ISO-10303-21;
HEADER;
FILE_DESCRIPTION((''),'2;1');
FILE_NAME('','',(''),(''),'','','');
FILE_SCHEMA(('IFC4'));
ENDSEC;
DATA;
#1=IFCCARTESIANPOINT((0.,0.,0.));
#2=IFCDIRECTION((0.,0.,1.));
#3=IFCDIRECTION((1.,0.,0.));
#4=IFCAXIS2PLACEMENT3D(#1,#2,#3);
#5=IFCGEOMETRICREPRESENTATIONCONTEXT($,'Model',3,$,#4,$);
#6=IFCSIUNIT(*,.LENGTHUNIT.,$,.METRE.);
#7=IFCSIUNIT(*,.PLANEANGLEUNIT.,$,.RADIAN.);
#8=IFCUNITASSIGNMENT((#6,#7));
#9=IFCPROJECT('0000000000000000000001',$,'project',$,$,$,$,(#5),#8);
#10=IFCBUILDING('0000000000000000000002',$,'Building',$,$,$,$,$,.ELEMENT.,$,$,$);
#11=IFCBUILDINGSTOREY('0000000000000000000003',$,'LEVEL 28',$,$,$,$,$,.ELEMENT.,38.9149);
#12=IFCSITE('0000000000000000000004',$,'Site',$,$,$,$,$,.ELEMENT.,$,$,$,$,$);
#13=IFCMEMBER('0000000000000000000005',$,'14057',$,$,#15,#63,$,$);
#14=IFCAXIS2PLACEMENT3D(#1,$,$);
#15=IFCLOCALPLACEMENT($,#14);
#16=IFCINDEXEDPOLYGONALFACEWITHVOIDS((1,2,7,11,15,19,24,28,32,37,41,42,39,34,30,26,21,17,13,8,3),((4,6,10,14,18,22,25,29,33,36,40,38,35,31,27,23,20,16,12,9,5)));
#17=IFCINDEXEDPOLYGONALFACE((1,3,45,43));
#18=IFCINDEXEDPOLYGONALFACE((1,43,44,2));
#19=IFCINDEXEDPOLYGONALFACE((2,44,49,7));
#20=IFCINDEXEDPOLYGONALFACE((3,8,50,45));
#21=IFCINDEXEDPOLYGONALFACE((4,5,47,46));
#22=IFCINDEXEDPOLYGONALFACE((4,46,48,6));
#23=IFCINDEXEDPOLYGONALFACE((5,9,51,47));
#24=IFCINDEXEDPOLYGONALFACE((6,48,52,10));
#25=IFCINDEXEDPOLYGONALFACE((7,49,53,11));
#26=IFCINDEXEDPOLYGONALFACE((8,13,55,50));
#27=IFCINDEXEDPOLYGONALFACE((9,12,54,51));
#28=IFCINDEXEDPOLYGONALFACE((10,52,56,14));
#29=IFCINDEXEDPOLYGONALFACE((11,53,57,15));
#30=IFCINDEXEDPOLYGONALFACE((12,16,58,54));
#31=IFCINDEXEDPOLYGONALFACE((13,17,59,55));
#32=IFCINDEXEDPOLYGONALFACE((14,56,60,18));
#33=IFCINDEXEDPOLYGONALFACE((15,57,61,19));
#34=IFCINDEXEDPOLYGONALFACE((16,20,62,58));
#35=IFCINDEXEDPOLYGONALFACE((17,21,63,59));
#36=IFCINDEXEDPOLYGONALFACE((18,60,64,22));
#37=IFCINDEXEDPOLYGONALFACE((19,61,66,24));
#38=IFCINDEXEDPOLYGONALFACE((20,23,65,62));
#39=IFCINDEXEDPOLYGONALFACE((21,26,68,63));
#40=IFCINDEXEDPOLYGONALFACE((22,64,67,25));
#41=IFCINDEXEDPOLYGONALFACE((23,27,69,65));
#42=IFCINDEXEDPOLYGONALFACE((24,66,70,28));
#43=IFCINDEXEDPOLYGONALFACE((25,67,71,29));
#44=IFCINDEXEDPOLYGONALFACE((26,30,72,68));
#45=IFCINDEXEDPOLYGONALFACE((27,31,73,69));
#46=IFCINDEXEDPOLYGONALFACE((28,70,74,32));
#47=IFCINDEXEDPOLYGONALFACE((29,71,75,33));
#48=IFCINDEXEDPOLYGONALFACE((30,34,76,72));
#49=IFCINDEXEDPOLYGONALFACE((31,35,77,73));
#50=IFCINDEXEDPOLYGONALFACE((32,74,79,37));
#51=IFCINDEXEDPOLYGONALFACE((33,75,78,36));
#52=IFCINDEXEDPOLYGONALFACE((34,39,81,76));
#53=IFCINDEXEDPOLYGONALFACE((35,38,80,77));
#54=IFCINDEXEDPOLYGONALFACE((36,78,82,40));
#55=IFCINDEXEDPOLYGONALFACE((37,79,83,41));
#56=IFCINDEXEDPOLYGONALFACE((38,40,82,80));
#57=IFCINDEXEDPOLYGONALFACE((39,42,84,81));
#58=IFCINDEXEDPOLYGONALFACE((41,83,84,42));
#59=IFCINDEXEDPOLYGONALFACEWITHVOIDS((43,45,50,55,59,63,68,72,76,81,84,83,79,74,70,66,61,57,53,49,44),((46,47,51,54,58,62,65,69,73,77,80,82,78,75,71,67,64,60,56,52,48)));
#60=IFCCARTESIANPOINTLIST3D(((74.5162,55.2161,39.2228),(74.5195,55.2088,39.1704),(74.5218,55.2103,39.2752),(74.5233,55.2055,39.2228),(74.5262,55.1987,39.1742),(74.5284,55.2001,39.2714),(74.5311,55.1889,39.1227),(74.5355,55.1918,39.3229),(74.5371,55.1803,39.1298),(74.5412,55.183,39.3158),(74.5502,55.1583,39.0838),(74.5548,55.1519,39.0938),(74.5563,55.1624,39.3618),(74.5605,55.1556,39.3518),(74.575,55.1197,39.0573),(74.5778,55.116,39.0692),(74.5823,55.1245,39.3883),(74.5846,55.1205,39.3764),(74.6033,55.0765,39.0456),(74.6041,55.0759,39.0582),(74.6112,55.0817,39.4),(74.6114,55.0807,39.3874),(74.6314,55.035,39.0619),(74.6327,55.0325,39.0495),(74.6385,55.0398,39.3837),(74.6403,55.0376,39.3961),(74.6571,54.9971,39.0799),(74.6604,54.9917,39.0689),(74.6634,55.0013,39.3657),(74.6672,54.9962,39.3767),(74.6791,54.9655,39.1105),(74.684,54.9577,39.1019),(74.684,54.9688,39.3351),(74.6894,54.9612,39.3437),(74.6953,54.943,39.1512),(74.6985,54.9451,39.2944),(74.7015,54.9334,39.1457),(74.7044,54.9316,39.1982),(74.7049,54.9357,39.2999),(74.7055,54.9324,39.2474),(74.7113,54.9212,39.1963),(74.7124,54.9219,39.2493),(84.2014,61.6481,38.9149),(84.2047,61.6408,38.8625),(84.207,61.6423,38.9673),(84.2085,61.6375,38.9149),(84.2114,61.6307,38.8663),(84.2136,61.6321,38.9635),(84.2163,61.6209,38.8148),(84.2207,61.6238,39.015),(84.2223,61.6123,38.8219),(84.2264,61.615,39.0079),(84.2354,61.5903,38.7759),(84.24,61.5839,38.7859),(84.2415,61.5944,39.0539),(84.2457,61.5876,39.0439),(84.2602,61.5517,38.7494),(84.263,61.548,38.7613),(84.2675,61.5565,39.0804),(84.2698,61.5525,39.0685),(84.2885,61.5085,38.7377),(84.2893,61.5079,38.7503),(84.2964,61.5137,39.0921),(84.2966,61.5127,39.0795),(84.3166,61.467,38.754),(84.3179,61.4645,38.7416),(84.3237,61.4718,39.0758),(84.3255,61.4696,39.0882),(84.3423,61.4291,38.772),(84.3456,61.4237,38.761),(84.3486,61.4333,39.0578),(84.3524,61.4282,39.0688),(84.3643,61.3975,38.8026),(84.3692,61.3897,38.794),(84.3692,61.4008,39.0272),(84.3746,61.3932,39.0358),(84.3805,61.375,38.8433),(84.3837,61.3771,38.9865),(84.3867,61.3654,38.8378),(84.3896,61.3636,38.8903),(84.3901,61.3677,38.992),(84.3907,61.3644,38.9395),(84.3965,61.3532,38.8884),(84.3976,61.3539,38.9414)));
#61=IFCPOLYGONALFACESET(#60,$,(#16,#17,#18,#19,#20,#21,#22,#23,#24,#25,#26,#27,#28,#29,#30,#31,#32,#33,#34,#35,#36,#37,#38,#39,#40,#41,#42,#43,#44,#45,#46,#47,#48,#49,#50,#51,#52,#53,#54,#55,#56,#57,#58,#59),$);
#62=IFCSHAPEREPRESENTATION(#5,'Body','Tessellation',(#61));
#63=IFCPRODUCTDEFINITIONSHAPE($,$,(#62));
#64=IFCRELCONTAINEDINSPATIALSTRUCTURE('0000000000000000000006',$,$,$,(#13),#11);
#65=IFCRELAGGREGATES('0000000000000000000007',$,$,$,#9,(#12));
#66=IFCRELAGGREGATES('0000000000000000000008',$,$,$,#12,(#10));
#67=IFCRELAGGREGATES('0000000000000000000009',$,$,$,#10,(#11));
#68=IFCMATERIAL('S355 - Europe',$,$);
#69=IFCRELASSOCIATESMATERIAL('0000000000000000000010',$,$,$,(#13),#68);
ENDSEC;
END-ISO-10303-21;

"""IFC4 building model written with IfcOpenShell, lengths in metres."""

from ifc_helpers import new_model, si_unit, frame, origin_with_axes, origin_2d_with_axis, place, context, project, spatial, hollow_circle, extrude, material, material_profile, profile_set, profile_usage, element, save


model = new_model("IFC4")

# Units and contexts
model_context = context("Model", 3, world=origin_with_axes())
ifc_project = project(units=[si_unit("LENGTHUNIT", "METRE"), si_unit("PLANEANGLEUNIT", "RADIAN")], contexts=[model_context])

# Site, building, storey
site = spatial("IfcSite", under=ifc_project, Name="Site", CompositionType="ELEMENT")
building = spatial("IfcBuilding", under=site, Name="Building", CompositionType="ELEMENT")
storey = spatial("IfcBuildingStorey", under=building, Name="LEVEL 28", CompositionType="ELEMENT", Elevation=38.9149)

# Shared definitions
ifc_material = material(Name="S355 - Europe")

# Member
ifc_material_profile_1 = material_profile(ifc_material, hollow_circle(Radius=0.1778, WallThickness=0.0127, at=origin_2d_with_axis()))
ifc_profile_set_1 = profile_set([ifc_material_profile_1])
ifc_profile_usage_1 = profile_usage(ifc_profile_set_1, cardinal=10)
member_1_placement = place(None, frame((74.6146, 55.068, 39.2228), z_axis=(0.832742, 0.553029, -0.026473), x_axis=(-0.553223, 0.833033, 0.0)))
element("IfcMember", 1, at=member_1_placement, inside=storey, material=ifc_profile_usage_1, Name="14057", context=model_context, shape_type="SweptSolid", body=[
    extrude(hollow_circle(Radius=0.1778, WallThickness=0.0127, at=origin_2d_with_axis()), origin_with_axes(), (0.0, 0.0, 1.0), 11.6305),
])

save(model, "model.ifc")
